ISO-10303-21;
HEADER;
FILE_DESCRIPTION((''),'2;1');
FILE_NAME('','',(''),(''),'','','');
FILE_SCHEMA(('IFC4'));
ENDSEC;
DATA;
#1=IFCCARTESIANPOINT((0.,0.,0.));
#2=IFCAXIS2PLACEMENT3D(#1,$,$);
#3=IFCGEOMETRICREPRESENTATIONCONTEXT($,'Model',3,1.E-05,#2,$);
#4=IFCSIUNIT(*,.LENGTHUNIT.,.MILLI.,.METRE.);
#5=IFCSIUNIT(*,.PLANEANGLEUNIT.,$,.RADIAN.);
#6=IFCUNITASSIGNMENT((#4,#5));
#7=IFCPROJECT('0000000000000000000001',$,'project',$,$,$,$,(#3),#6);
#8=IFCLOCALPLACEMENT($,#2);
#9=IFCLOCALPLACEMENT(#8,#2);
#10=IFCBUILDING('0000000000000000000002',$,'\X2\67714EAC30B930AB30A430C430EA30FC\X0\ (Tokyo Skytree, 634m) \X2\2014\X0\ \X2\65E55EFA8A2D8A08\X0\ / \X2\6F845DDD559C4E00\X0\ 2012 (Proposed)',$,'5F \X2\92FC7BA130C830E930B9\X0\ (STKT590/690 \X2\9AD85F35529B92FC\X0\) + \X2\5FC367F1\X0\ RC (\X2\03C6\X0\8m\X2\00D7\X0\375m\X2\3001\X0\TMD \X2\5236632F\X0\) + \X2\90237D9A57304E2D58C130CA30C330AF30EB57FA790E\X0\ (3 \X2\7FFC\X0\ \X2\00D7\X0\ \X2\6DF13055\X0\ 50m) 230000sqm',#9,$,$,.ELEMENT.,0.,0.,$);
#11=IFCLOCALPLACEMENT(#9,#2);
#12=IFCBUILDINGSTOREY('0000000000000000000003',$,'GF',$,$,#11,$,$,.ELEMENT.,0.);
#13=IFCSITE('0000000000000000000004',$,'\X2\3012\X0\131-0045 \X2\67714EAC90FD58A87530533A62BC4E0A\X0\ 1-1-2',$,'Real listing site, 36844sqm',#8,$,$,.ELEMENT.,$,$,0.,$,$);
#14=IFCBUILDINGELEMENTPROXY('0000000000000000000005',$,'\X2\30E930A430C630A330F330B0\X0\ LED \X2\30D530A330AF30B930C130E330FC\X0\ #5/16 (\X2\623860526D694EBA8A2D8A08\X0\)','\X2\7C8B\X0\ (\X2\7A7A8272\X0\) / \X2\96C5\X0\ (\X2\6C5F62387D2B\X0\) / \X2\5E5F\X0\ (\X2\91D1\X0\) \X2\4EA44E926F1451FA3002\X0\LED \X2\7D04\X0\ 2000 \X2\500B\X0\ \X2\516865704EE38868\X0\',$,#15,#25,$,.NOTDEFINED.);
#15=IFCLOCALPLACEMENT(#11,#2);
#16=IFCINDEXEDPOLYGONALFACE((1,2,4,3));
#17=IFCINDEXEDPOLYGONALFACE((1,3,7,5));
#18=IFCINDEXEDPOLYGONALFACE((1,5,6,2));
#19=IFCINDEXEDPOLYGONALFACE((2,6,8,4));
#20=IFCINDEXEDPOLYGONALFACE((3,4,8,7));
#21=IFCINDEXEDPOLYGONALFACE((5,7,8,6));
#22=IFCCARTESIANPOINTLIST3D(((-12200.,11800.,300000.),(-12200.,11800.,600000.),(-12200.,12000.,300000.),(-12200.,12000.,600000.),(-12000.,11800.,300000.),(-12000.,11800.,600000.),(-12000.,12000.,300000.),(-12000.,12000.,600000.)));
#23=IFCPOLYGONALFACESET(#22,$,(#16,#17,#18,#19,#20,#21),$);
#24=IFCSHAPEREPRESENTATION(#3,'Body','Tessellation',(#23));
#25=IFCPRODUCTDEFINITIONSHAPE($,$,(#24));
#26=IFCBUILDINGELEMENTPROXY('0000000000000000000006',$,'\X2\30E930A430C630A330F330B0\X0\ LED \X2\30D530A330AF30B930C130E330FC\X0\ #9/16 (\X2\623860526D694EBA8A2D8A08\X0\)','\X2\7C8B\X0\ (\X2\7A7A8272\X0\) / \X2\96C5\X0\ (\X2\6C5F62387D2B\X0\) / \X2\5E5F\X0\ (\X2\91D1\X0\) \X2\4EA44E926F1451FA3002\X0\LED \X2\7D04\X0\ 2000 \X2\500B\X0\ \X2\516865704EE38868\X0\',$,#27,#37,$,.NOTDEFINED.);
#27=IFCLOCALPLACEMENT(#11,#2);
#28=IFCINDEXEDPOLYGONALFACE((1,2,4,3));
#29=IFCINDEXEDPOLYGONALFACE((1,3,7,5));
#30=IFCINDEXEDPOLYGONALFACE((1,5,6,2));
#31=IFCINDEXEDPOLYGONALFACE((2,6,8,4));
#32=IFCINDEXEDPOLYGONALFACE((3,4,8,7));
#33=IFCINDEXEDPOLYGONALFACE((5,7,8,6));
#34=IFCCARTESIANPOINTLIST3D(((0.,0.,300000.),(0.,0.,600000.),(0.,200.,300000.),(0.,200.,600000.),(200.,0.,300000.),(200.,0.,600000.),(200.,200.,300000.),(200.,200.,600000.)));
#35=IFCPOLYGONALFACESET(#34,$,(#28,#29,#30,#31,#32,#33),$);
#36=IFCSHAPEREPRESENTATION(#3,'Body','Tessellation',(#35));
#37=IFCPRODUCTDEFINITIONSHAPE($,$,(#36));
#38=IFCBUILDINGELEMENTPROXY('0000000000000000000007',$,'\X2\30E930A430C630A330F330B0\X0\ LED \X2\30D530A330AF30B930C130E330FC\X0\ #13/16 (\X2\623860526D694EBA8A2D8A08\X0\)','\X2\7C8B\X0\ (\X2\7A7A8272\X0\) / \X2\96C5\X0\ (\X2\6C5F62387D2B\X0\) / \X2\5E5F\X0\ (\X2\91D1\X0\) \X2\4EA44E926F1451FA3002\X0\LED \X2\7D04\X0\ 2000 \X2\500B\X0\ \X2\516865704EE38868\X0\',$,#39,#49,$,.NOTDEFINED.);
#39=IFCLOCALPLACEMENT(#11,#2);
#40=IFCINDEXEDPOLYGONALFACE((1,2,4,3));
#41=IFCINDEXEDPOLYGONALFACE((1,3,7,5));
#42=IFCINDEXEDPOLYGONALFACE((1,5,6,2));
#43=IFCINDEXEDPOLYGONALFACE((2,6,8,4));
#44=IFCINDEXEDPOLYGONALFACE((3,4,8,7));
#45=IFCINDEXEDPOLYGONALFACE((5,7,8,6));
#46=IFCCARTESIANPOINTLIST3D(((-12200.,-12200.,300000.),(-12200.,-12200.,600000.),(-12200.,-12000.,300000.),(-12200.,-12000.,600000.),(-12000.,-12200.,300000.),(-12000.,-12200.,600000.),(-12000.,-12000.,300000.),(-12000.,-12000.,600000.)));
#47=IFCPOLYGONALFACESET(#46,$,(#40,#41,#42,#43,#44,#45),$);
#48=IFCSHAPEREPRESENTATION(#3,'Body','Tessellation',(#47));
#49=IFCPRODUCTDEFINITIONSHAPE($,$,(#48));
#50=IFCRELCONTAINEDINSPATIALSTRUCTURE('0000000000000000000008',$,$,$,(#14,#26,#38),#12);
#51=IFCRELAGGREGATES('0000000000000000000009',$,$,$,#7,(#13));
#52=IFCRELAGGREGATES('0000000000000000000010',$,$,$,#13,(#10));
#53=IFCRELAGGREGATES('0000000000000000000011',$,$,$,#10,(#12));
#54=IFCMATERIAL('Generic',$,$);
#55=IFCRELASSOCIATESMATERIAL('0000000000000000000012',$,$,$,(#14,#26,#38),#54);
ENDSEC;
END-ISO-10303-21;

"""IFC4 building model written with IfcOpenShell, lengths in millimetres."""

from ifc_helpers import new_model, si_unit, frame, frame_2d, origin, place, context, project, spatial, rectangle, extrude, material, element, save


model = new_model("IFC4")

# Units and contexts
model_context = context("Model", 3, precision=1e-05, world=origin())
ifc_project = project(units=[si_unit("LENGTHUNIT", "METRE", prefix="MILLI"), si_unit("PLANEANGLEUNIT", "RADIAN")], contexts=[model_context])

# Site, building, storey
site_placement = place(None, origin())
site = spatial("IfcSite", under=ifc_project, at=site_placement, Name="〒131-0045 東京都墨田区押上 1-1-2", ObjectType="Real listing site, 36844sqm", CompositionType="ELEMENT", RefElevation=0.0)
building_placement = place(site_placement, origin())
building = spatial("IfcBuilding", under=site, at=building_placement, Name="東京スカイツリー (Tokyo Skytree, 634m) — 日建設計 / 澄川喜一 2012 (Proposed)", ObjectType="5F 鋼管トラス (STKT590/690 高張力鋼) + 心柱 RC (φ8m×375m、TMD 制振) + 連続地中壁ナックル基礎 (3 翼 × 深さ 50m) 230000sqm", CompositionType="ELEMENT", ElevationOfRefHeight=0.0, ElevationOfTerrain=0.0)
storey_placement = place(building_placement, origin())
storey = spatial("IfcBuildingStorey", under=building, at=storey_placement, Name="GF", CompositionType="ELEMENT", Elevation=0.0)

# Shared definitions
ifc_material = material(Name="Generic")

# Building element proxies
proxy_1_placement = place(storey_placement, frame((0.0, 12000.0, 150000.0), x_axis=(0.0, 1.0, 0.0)))
element("IfcBuildingElementProxy", 1, at=proxy_1_placement, inside=storey, material=ifc_material, Name="ライティング LED フィクスチャー #5/16 (戸恒浩人設計)", Description="粋 (空色) / 雅 (江戸紫) / 幟 (金) 交互演出。LED 約 2000 個 全数代表", PredefinedType="NOTDEFINED", context=model_context, shape_type="SweptSolid", body=[
    extrude(rectangle(XDim=200.0, YDim=200.0, at=frame_2d((100.0, 100.0))), frame((0.0, 12000.0, 150000.0), x_axis=(0.0, 1.0, 0.0)), (0.0, 0.0, 1.0), 300000.0),
])
proxy_2_placement = place(storey_placement, frame((-12000.0, 0.0, 150000.0), x_axis=(-1.0, 0.0, 0.0)))
element("IfcBuildingElementProxy", 2, at=proxy_2_placement, inside=storey, material=ifc_material, Name="ライティング LED フィクスチャー #9/16 (戸恒浩人設計)", Description="粋 (空色) / 雅 (江戸紫) / 幟 (金) 交互演出。LED 約 2000 個 全数代表", PredefinedType="NOTDEFINED", context=model_context, shape_type="SweptSolid", body=[
    extrude(rectangle(XDim=200.0, YDim=200.0, at=frame_2d((100.0, 100.0))), frame((-12000.0, 0.0, 150000.0), x_axis=(-1.0, 0.0, 0.0)), (0.0, 0.0, 1.0), 300000.0),
])
proxy_3_placement = place(storey_placement, frame((0.0, -12000.0, 150000.0), x_axis=(0.0, -1.0, 0.0)))
element("IfcBuildingElementProxy", 3, at=proxy_3_placement, inside=storey, material=ifc_material, Name="ライティング LED フィクスチャー #13/16 (戸恒浩人設計)", Description="粋 (空色) / 雅 (江戸紫) / 幟 (金) 交互演出。LED 約 2000 個 全数代表", PredefinedType="NOTDEFINED", context=model_context, shape_type="SweptSolid", body=[
    extrude(rectangle(XDim=200.0, YDim=200.0, at=frame_2d((100.0, 100.0))), frame((0.0, -12000.0, 150000.0), x_axis=(0.0, -1.0, 0.0)), (0.0, 0.0, 1.0), 300000.0),
])

save(model, "model.ifc")
